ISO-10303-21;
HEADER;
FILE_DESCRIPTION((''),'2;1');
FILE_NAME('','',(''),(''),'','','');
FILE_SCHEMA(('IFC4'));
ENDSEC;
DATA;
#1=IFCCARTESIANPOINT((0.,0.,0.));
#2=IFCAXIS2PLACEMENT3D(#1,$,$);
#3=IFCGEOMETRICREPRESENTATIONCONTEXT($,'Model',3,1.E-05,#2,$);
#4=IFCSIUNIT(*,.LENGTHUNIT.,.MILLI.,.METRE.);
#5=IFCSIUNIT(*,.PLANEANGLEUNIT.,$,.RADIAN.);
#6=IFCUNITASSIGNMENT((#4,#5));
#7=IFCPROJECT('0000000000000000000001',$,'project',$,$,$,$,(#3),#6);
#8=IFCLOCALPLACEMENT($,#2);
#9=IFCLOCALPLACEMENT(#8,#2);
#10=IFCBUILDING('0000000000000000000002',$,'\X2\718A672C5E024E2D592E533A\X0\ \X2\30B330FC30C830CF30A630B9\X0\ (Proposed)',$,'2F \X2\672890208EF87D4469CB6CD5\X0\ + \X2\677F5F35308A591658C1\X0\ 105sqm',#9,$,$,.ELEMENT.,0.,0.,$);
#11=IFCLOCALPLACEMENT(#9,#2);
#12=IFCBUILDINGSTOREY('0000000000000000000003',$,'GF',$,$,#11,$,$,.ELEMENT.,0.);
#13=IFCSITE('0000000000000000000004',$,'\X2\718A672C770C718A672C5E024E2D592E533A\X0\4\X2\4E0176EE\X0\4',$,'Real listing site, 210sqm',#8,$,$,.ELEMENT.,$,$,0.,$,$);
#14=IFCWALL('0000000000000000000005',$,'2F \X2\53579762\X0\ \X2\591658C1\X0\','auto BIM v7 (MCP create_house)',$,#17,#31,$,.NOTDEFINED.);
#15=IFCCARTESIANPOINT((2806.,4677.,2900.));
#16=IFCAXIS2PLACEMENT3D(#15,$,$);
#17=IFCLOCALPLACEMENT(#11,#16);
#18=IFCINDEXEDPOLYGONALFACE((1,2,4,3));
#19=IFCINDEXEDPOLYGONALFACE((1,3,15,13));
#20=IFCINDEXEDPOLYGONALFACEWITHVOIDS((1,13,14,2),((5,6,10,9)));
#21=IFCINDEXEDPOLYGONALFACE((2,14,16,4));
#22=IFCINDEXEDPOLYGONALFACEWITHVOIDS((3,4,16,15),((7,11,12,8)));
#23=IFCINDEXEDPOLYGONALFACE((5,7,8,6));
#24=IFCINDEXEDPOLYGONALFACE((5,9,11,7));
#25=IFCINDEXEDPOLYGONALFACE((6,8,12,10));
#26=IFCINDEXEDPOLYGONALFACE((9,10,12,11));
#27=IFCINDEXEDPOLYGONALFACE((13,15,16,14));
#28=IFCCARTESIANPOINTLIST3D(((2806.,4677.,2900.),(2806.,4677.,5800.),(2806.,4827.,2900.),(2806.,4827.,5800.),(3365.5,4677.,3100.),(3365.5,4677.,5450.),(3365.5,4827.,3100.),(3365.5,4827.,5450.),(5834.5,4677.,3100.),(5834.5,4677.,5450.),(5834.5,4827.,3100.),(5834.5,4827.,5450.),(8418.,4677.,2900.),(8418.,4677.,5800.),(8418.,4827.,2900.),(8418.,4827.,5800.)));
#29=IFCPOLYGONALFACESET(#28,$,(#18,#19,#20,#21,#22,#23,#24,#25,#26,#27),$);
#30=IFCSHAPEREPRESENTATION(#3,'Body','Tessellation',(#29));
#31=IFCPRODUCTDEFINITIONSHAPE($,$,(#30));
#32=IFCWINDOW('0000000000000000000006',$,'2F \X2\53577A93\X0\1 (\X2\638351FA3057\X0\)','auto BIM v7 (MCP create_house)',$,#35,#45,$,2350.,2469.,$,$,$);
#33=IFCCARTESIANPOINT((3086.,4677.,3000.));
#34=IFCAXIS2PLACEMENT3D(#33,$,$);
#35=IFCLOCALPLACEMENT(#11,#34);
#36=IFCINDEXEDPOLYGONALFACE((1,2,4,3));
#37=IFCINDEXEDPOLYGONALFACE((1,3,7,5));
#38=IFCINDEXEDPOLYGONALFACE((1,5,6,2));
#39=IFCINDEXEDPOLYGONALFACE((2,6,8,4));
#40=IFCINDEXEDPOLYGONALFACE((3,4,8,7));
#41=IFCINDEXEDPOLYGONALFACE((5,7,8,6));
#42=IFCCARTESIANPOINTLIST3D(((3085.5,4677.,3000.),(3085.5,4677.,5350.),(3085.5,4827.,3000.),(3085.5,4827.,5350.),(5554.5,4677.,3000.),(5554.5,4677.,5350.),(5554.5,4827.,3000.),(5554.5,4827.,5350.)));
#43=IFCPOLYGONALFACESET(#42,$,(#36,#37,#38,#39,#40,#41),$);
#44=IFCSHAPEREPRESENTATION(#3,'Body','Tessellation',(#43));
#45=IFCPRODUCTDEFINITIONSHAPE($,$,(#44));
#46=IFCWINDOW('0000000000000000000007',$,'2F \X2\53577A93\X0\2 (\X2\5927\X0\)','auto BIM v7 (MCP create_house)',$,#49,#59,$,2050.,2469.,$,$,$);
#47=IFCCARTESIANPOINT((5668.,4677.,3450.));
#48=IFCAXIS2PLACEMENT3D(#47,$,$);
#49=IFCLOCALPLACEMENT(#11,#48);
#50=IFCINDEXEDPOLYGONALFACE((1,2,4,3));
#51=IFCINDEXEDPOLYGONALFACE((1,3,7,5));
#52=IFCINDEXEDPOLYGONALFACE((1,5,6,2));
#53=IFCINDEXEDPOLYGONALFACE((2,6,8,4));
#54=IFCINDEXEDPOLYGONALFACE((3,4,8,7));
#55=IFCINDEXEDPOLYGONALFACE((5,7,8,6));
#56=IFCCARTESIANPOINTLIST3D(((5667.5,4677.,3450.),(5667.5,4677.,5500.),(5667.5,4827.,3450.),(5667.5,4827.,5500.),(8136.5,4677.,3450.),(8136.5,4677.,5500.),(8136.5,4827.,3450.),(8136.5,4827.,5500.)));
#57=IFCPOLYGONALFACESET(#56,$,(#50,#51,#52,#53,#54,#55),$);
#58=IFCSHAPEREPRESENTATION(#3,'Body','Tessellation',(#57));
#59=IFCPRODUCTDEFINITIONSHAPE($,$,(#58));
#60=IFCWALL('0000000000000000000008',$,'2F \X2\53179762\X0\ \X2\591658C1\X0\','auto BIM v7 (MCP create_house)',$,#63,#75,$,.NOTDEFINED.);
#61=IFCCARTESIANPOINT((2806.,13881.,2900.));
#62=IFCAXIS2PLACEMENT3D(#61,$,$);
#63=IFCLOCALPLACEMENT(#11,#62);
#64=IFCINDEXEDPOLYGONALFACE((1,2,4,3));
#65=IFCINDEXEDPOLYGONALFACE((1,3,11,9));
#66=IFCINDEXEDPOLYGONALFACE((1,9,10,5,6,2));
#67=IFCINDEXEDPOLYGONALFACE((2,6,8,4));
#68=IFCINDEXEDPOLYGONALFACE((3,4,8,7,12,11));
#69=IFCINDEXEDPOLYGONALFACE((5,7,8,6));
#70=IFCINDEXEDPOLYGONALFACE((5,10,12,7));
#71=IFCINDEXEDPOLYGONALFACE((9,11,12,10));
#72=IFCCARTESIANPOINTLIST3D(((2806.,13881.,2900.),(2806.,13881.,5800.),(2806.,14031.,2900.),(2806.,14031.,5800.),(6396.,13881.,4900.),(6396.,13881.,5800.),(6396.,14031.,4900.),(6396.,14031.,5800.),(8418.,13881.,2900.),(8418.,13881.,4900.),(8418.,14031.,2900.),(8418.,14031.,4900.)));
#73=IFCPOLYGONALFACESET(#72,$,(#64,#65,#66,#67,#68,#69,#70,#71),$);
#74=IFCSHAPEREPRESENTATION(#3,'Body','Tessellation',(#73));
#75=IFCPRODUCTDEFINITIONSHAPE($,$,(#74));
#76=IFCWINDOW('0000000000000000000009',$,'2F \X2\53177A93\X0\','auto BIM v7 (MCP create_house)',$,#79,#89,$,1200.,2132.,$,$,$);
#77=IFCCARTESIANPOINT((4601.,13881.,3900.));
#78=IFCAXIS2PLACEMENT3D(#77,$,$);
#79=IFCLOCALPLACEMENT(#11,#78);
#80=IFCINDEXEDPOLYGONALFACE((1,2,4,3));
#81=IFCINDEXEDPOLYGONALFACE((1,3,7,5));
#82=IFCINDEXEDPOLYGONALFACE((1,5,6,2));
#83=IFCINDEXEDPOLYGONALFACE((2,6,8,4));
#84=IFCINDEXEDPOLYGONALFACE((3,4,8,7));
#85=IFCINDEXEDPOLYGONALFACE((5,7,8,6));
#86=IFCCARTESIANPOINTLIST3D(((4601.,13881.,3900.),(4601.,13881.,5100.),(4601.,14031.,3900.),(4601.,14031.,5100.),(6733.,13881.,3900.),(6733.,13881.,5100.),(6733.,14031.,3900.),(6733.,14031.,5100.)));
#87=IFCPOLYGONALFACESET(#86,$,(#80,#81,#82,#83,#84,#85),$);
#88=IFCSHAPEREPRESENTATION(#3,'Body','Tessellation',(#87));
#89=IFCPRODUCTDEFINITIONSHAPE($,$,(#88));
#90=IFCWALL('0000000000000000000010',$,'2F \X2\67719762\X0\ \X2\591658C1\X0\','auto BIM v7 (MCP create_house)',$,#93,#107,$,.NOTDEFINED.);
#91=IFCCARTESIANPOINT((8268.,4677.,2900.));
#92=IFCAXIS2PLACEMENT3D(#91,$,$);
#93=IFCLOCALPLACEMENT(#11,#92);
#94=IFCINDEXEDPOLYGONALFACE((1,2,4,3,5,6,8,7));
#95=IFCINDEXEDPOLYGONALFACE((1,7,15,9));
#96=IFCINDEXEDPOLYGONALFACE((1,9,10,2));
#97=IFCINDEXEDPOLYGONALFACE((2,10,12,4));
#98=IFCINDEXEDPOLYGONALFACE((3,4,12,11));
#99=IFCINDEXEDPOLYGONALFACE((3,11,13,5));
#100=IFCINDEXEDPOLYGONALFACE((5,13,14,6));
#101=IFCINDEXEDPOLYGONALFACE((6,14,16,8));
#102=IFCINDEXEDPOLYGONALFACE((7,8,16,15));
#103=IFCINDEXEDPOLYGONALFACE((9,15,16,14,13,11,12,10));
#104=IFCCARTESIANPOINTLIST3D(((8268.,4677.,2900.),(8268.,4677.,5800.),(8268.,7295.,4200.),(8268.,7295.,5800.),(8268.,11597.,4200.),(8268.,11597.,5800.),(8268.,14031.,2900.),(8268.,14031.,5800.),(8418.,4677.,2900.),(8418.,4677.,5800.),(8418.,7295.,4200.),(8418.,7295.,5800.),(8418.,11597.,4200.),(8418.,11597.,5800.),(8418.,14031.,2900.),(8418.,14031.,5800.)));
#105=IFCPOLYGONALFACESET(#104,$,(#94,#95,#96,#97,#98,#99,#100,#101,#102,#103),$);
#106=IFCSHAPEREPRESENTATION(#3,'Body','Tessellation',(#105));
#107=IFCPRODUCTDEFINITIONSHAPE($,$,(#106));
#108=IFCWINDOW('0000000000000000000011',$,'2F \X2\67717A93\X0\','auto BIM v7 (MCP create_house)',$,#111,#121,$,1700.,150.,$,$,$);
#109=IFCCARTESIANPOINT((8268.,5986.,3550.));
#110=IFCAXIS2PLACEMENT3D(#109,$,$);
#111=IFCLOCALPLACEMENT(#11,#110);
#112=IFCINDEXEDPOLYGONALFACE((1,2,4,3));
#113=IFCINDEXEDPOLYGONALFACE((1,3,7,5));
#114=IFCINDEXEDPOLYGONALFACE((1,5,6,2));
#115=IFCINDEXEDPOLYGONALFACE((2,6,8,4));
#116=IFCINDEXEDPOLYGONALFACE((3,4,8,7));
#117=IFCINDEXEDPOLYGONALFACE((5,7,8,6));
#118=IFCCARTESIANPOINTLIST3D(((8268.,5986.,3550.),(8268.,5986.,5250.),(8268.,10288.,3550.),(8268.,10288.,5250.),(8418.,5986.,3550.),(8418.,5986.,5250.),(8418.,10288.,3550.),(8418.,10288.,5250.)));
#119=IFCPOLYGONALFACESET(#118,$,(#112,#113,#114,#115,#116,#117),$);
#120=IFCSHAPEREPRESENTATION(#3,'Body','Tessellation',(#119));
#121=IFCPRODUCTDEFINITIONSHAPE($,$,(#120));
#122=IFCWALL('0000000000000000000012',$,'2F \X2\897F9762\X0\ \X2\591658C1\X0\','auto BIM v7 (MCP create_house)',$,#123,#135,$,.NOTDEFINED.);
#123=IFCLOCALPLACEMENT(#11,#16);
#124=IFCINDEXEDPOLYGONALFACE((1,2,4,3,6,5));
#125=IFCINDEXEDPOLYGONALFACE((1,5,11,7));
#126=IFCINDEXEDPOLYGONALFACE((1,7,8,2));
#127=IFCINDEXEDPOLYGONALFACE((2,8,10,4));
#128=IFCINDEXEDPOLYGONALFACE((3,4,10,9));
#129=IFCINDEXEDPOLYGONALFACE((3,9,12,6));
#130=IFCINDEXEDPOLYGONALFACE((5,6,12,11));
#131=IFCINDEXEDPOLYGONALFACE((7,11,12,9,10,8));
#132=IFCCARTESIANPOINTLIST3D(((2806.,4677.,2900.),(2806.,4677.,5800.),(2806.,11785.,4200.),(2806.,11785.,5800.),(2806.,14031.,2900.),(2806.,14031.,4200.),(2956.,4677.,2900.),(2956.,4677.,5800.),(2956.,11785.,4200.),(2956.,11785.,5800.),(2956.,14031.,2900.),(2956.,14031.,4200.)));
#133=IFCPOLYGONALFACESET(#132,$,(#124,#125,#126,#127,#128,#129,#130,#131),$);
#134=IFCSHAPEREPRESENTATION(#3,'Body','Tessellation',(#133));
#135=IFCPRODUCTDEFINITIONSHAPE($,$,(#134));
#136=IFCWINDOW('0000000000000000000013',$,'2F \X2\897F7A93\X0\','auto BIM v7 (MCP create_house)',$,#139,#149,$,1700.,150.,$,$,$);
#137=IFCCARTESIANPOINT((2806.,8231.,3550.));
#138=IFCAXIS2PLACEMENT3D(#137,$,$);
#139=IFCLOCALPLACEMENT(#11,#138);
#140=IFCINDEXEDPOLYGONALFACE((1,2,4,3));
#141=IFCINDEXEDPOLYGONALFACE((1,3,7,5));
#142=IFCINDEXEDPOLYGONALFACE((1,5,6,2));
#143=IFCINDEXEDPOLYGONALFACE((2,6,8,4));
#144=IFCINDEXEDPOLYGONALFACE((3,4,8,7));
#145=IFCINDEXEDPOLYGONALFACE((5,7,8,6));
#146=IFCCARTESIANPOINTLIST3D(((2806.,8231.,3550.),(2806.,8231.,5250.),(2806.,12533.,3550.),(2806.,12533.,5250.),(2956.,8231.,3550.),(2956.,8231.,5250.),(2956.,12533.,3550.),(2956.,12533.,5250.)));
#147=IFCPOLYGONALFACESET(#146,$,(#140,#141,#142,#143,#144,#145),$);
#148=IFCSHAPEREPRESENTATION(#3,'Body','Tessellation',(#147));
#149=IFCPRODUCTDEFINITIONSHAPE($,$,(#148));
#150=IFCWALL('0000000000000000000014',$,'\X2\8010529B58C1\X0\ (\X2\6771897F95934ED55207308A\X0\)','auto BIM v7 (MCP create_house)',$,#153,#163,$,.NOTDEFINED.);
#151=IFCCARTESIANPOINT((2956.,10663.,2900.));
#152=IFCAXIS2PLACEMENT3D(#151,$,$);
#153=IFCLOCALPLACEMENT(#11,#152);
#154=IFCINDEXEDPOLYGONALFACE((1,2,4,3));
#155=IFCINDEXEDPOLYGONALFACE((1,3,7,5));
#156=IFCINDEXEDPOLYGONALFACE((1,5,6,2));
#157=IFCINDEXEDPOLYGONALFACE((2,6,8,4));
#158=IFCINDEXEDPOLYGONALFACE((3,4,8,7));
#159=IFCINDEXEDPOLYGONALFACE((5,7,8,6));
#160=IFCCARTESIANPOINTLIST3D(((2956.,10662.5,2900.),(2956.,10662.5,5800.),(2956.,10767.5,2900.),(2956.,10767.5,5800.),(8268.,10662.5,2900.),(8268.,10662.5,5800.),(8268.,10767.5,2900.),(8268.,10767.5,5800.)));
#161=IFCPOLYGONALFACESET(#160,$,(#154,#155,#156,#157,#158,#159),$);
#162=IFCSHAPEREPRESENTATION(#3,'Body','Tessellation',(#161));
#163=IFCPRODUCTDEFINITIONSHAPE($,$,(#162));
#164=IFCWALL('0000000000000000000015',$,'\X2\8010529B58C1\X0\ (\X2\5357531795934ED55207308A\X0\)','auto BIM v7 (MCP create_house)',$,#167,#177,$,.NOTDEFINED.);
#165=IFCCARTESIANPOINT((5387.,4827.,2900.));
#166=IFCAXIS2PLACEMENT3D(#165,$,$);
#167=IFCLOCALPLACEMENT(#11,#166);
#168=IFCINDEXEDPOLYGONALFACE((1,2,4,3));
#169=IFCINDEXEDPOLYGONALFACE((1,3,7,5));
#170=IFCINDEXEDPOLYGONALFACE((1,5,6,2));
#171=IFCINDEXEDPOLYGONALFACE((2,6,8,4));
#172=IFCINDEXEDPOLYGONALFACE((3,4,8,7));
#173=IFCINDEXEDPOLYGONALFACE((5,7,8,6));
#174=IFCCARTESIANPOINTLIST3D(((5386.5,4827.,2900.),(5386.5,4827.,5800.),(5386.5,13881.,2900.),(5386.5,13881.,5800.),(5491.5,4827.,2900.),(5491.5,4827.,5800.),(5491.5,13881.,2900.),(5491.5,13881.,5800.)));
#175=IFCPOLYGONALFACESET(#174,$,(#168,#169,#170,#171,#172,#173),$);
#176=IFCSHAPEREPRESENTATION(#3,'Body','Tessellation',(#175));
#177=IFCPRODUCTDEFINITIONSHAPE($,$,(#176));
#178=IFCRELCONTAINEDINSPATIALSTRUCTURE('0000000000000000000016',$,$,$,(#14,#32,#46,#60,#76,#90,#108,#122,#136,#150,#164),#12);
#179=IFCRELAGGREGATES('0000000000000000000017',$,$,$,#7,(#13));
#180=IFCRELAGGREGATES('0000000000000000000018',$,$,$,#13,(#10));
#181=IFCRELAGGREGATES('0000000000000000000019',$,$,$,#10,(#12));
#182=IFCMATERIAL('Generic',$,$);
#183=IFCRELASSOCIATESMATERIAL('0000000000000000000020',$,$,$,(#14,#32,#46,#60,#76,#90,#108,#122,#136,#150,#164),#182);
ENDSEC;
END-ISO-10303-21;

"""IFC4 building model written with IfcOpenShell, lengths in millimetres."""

from ifc_helpers import new_model, si_unit, frame, frame_2d, origin, place, context, project, spatial, rectangle, extrude, material, element, fill, save


model = new_model("IFC4")

# Units and contexts
model_context = context("Model", 3, precision=1e-05, world=origin())
ifc_project = project(units=[si_unit("LENGTHUNIT", "METRE", prefix="MILLI"), si_unit("PLANEANGLEUNIT", "RADIAN")], contexts=[model_context])

# Site, building, storey
site_placement = place(None, origin())
site = spatial("IfcSite", under=ifc_project, at=site_placement, Name="熊本県熊本市中央区4丁目4", ObjectType="Real listing site, 210sqm", CompositionType="ELEMENT", RefElevation=0.0)
building_placement = place(site_placement, origin())
building = spatial("IfcBuilding", under=site, at=building_placement, Name="熊本市中央区 コートハウス (Proposed)", ObjectType="2F 木造軸組構法 + 板張り外壁 105sqm", CompositionType="ELEMENT", ElevationOfRefHeight=0.0, ElevationOfTerrain=0.0)
storey_placement = place(building_placement, origin())
storey = spatial("IfcBuildingStorey", under=building, at=storey_placement, Name="GF", CompositionType="ELEMENT", Elevation=0.0)

# Shared definitions
ifc_material = material(Name="Generic")

# Wall, openings, windows
wall_1_placement = place(storey_placement, frame((2806.0, 4677.0, 2900.0)))
wall_1 = element("IfcWall", 1, at=wall_1_placement, inside=storey, material=ifc_material, Name="2F 南面 外壁", Description="auto BIM v7 (MCP create_house)", PredefinedType="NOTDEFINED", context=model_context, shape_type="SweptSolid", body=[
    extrude(rectangle(XDim=5612.0, YDim=150.0, at=frame_2d((2806.0, 75.0))), frame((2806.0, 4677.0, 2900.0)), (0.0, 0.0, 1.0), 2900.0),
])
opening_1_placement = place(storey_placement, frame((3086.0, 4677.0, 3000.0)))
opening_1 = element("IfcOpeningElement", 2, at=opening_1_placement, cuts=wall_1, PredefinedType="NOTDEFINED", context=model_context, shape_type="SweptSolid", body=[
    extrude(rectangle(XDim=2469.0, YDim=150.0, at=frame_2d((1234.0, 75.0))), frame((3086.0, 4677.0, 3000.0)), (0.0, 0.0, 1.0), 2350.0),
])
opening_2_placement = place(storey_placement, frame((5668.0, 4677.0, 3450.0)))
opening_2 = element("IfcOpeningElement", 3, at=opening_2_placement, cuts=wall_1, PredefinedType="NOTDEFINED", context=model_context, shape_type="SweptSolid", body=[
    extrude(rectangle(XDim=2469.0, YDim=150.0, at=frame_2d((1234.0, 75.0))), frame((5668.0, 4677.0, 3450.0)), (0.0, 0.0, 1.0), 2050.0),
])
window_1_placement = place(storey_placement, frame((3086.0, 4677.0, 3000.0)))
window_1 = element("IfcWindow", 4, at=window_1_placement, inside=storey, material=ifc_material, Name="2F 南窓1 (掃出し)", Description="auto BIM v7 (MCP create_house)", OverallHeight=2350.0, OverallWidth=2469.0, context=model_context, shape_type="SweptSolid", body=[
    extrude(rectangle(XDim=2469.0, YDim=150.0, at=frame_2d((1234.0, 75.0))), frame((3086.0, 4677.0, 3000.0)), (0.0, 0.0, 1.0), 2350.0),
])
fill(opening_1, window_1)
window_2_placement = place(storey_placement, frame((5668.0, 4677.0, 3450.0)))
window_2 = element("IfcWindow", 5, at=window_2_placement, inside=storey, material=ifc_material, Name="2F 南窓2 (大)", Description="auto BIM v7 (MCP create_house)", OverallHeight=2050.0, OverallWidth=2469.0, context=model_context, shape_type="SweptSolid", body=[
    extrude(rectangle(XDim=2469.0, YDim=150.0, at=frame_2d((1234.0, 75.0))), frame((5668.0, 4677.0, 3450.0)), (0.0, 0.0, 1.0), 2050.0),
])
fill(opening_2, window_2)

# Walls, openings, windows
wall_2_placement = place(storey_placement, frame((2806.0, 13881.0, 2900.0)))
wall_2 = element("IfcWall", 6, at=wall_2_placement, inside=storey, material=ifc_material, Name="2F 北面 外壁", Description="auto BIM v7 (MCP create_house)", PredefinedType="NOTDEFINED", context=model_context, shape_type="SweptSolid", body=[
    extrude(rectangle(XDim=5612.0, YDim=150.0, at=frame_2d((2806.0, 75.0))), frame((2806.0, 13881.0, 2900.0)), (0.0, 0.0, 1.0), 2900.0),
])
opening_3_placement = place(storey_placement, frame((4601.0, 13881.0, 3900.0)))
opening_3 = element("IfcOpeningElement", 7, at=opening_3_placement, cuts=wall_2, PredefinedType="NOTDEFINED", context=model_context, shape_type="SweptSolid", body=[
    extrude(rectangle(XDim=2132.0, YDim=150.0, at=frame_2d((1066.0, 75.0))), frame((4601.0, 13881.0, 3900.0)), (0.0, 0.0, 1.0), 1200.0),
])
window_3_placement = place(storey_placement, frame((4601.0, 13881.0, 3900.0)))
window_3 = element("IfcWindow", 8, at=window_3_placement, inside=storey, material=ifc_material, Name="2F 北窓", Description="auto BIM v7 (MCP create_house)", OverallHeight=1200.0, OverallWidth=2132.0, context=model_context, shape_type="SweptSolid", body=[
    extrude(rectangle(XDim=2132.0, YDim=150.0, at=frame_2d((1066.0, 75.0))), frame((4601.0, 13881.0, 3900.0)), (0.0, 0.0, 1.0), 1200.0),
])
fill(opening_3, window_3)
wall_3_placement = place(storey_placement, frame((8268.0, 4677.0, 2900.0)))
wall_3 = element("IfcWall", 9, at=wall_3_placement, inside=storey, material=ifc_material, Name="2F 東面 外壁", Description="auto BIM v7 (MCP create_house)", PredefinedType="NOTDEFINED", context=model_context, shape_type="SweptSolid", body=[
    extrude(rectangle(XDim=150.0, YDim=9354.0, at=frame_2d((75.0, 4677.0))), frame((8268.0, 4677.0, 2900.0)), (0.0, 0.0, 1.0), 2900.0),
])
opening_4_placement = place(storey_placement, frame((8268.0, 5986.0, 3550.0)))
opening_4 = element("IfcOpeningElement", 10, at=opening_4_placement, cuts=wall_3, PredefinedType="NOTDEFINED", context=model_context, shape_type="SweptSolid", body=[
    extrude(rectangle(XDim=150.0, YDim=4302.0, at=frame_2d((75.0, 2151.0))), frame((8268.0, 5986.0, 3550.0)), (0.0, 0.0, 1.0), 1700.0),
])
window_4_placement = place(storey_placement, frame((8268.0, 5986.0, 3550.0)))
window_4 = element("IfcWindow", 11, at=window_4_placement, inside=storey, material=ifc_material, Name="2F 東窓", Description="auto BIM v7 (MCP create_house)", OverallHeight=1700.0, OverallWidth=150.0, context=model_context, shape_type="SweptSolid", body=[
    extrude(rectangle(XDim=150.0, YDim=4302.0, at=frame_2d((75.0, 2151.0))), frame((8268.0, 5986.0, 3550.0)), (0.0, 0.0, 1.0), 1700.0),
])
fill(opening_4, window_4)
wall_4_placement = place(storey_placement, frame((2806.0, 4677.0, 2900.0)))
wall_4 = element("IfcWall", 12, at=wall_4_placement, inside=storey, material=ifc_material, Name="2F 西面 外壁", Description="auto BIM v7 (MCP create_house)", PredefinedType="NOTDEFINED", context=model_context, shape_type="SweptSolid", body=[
    extrude(rectangle(XDim=150.0, YDim=9354.0, at=frame_2d((75.0, 4677.0))), frame((2806.0, 4677.0, 2900.0)), (0.0, 0.0, 1.0), 2900.0),
])
opening_5_placement = place(storey_placement, frame((2806.0, 8231.0, 3550.0)))
opening_5 = element("IfcOpeningElement", 13, at=opening_5_placement, cuts=wall_4, PredefinedType="NOTDEFINED", context=model_context, shape_type="SweptSolid", body=[
    extrude(rectangle(XDim=150.0, YDim=4302.0, at=frame_2d((75.0, 2151.0))), frame((2806.0, 8231.0, 3550.0)), (0.0, 0.0, 1.0), 1700.0),
])
window_5_placement = place(storey_placement, frame((2806.0, 8231.0, 3550.0)))
window_5 = element("IfcWindow", 14, at=window_5_placement, inside=storey, material=ifc_material, Name="2F 西窓", Description="auto BIM v7 (MCP create_house)", OverallHeight=1700.0, OverallWidth=150.0, context=model_context, shape_type="SweptSolid", body=[
    extrude(rectangle(XDim=150.0, YDim=4302.0, at=frame_2d((75.0, 2151.0))), frame((2806.0, 8231.0, 3550.0)), (0.0, 0.0, 1.0), 1700.0),
])
fill(opening_5, window_5)

# Walls
wall_5_placement = place(storey_placement, frame((2956.0, 10663.0, 2900.0)))
element("IfcWall", 15, at=wall_5_placement, inside=storey, material=ifc_material, Name="耐力壁 (東西間仕切り)", Description="auto BIM v7 (MCP create_house)", PredefinedType="NOTDEFINED", context=model_context, shape_type="SweptSolid", body=[
    extrude(rectangle(XDim=5312.0, YDim=105.0, at=frame_2d((2656.0, 52.0))), frame((2956.0, 10663.0, 2900.0)), (0.0, 0.0, 1.0), 2900.0),
])
wall_6_placement = place(storey_placement, frame((5387.0, 4827.0, 2900.0)))
element("IfcWall", 16, at=wall_6_placement, inside=storey, material=ifc_material, Name="耐力壁 (南北間仕切り)", Description="auto BIM v7 (MCP create_house)", PredefinedType="NOTDEFINED", context=model_context, shape_type="SweptSolid", body=[
    extrude(rectangle(XDim=105.0, YDim=9054.0, at=frame_2d((52.0, 4527.0))), frame((5387.0, 4827.0, 2900.0)), (0.0, 0.0, 1.0), 2900.0),
])

save(model, "model.ifc")
